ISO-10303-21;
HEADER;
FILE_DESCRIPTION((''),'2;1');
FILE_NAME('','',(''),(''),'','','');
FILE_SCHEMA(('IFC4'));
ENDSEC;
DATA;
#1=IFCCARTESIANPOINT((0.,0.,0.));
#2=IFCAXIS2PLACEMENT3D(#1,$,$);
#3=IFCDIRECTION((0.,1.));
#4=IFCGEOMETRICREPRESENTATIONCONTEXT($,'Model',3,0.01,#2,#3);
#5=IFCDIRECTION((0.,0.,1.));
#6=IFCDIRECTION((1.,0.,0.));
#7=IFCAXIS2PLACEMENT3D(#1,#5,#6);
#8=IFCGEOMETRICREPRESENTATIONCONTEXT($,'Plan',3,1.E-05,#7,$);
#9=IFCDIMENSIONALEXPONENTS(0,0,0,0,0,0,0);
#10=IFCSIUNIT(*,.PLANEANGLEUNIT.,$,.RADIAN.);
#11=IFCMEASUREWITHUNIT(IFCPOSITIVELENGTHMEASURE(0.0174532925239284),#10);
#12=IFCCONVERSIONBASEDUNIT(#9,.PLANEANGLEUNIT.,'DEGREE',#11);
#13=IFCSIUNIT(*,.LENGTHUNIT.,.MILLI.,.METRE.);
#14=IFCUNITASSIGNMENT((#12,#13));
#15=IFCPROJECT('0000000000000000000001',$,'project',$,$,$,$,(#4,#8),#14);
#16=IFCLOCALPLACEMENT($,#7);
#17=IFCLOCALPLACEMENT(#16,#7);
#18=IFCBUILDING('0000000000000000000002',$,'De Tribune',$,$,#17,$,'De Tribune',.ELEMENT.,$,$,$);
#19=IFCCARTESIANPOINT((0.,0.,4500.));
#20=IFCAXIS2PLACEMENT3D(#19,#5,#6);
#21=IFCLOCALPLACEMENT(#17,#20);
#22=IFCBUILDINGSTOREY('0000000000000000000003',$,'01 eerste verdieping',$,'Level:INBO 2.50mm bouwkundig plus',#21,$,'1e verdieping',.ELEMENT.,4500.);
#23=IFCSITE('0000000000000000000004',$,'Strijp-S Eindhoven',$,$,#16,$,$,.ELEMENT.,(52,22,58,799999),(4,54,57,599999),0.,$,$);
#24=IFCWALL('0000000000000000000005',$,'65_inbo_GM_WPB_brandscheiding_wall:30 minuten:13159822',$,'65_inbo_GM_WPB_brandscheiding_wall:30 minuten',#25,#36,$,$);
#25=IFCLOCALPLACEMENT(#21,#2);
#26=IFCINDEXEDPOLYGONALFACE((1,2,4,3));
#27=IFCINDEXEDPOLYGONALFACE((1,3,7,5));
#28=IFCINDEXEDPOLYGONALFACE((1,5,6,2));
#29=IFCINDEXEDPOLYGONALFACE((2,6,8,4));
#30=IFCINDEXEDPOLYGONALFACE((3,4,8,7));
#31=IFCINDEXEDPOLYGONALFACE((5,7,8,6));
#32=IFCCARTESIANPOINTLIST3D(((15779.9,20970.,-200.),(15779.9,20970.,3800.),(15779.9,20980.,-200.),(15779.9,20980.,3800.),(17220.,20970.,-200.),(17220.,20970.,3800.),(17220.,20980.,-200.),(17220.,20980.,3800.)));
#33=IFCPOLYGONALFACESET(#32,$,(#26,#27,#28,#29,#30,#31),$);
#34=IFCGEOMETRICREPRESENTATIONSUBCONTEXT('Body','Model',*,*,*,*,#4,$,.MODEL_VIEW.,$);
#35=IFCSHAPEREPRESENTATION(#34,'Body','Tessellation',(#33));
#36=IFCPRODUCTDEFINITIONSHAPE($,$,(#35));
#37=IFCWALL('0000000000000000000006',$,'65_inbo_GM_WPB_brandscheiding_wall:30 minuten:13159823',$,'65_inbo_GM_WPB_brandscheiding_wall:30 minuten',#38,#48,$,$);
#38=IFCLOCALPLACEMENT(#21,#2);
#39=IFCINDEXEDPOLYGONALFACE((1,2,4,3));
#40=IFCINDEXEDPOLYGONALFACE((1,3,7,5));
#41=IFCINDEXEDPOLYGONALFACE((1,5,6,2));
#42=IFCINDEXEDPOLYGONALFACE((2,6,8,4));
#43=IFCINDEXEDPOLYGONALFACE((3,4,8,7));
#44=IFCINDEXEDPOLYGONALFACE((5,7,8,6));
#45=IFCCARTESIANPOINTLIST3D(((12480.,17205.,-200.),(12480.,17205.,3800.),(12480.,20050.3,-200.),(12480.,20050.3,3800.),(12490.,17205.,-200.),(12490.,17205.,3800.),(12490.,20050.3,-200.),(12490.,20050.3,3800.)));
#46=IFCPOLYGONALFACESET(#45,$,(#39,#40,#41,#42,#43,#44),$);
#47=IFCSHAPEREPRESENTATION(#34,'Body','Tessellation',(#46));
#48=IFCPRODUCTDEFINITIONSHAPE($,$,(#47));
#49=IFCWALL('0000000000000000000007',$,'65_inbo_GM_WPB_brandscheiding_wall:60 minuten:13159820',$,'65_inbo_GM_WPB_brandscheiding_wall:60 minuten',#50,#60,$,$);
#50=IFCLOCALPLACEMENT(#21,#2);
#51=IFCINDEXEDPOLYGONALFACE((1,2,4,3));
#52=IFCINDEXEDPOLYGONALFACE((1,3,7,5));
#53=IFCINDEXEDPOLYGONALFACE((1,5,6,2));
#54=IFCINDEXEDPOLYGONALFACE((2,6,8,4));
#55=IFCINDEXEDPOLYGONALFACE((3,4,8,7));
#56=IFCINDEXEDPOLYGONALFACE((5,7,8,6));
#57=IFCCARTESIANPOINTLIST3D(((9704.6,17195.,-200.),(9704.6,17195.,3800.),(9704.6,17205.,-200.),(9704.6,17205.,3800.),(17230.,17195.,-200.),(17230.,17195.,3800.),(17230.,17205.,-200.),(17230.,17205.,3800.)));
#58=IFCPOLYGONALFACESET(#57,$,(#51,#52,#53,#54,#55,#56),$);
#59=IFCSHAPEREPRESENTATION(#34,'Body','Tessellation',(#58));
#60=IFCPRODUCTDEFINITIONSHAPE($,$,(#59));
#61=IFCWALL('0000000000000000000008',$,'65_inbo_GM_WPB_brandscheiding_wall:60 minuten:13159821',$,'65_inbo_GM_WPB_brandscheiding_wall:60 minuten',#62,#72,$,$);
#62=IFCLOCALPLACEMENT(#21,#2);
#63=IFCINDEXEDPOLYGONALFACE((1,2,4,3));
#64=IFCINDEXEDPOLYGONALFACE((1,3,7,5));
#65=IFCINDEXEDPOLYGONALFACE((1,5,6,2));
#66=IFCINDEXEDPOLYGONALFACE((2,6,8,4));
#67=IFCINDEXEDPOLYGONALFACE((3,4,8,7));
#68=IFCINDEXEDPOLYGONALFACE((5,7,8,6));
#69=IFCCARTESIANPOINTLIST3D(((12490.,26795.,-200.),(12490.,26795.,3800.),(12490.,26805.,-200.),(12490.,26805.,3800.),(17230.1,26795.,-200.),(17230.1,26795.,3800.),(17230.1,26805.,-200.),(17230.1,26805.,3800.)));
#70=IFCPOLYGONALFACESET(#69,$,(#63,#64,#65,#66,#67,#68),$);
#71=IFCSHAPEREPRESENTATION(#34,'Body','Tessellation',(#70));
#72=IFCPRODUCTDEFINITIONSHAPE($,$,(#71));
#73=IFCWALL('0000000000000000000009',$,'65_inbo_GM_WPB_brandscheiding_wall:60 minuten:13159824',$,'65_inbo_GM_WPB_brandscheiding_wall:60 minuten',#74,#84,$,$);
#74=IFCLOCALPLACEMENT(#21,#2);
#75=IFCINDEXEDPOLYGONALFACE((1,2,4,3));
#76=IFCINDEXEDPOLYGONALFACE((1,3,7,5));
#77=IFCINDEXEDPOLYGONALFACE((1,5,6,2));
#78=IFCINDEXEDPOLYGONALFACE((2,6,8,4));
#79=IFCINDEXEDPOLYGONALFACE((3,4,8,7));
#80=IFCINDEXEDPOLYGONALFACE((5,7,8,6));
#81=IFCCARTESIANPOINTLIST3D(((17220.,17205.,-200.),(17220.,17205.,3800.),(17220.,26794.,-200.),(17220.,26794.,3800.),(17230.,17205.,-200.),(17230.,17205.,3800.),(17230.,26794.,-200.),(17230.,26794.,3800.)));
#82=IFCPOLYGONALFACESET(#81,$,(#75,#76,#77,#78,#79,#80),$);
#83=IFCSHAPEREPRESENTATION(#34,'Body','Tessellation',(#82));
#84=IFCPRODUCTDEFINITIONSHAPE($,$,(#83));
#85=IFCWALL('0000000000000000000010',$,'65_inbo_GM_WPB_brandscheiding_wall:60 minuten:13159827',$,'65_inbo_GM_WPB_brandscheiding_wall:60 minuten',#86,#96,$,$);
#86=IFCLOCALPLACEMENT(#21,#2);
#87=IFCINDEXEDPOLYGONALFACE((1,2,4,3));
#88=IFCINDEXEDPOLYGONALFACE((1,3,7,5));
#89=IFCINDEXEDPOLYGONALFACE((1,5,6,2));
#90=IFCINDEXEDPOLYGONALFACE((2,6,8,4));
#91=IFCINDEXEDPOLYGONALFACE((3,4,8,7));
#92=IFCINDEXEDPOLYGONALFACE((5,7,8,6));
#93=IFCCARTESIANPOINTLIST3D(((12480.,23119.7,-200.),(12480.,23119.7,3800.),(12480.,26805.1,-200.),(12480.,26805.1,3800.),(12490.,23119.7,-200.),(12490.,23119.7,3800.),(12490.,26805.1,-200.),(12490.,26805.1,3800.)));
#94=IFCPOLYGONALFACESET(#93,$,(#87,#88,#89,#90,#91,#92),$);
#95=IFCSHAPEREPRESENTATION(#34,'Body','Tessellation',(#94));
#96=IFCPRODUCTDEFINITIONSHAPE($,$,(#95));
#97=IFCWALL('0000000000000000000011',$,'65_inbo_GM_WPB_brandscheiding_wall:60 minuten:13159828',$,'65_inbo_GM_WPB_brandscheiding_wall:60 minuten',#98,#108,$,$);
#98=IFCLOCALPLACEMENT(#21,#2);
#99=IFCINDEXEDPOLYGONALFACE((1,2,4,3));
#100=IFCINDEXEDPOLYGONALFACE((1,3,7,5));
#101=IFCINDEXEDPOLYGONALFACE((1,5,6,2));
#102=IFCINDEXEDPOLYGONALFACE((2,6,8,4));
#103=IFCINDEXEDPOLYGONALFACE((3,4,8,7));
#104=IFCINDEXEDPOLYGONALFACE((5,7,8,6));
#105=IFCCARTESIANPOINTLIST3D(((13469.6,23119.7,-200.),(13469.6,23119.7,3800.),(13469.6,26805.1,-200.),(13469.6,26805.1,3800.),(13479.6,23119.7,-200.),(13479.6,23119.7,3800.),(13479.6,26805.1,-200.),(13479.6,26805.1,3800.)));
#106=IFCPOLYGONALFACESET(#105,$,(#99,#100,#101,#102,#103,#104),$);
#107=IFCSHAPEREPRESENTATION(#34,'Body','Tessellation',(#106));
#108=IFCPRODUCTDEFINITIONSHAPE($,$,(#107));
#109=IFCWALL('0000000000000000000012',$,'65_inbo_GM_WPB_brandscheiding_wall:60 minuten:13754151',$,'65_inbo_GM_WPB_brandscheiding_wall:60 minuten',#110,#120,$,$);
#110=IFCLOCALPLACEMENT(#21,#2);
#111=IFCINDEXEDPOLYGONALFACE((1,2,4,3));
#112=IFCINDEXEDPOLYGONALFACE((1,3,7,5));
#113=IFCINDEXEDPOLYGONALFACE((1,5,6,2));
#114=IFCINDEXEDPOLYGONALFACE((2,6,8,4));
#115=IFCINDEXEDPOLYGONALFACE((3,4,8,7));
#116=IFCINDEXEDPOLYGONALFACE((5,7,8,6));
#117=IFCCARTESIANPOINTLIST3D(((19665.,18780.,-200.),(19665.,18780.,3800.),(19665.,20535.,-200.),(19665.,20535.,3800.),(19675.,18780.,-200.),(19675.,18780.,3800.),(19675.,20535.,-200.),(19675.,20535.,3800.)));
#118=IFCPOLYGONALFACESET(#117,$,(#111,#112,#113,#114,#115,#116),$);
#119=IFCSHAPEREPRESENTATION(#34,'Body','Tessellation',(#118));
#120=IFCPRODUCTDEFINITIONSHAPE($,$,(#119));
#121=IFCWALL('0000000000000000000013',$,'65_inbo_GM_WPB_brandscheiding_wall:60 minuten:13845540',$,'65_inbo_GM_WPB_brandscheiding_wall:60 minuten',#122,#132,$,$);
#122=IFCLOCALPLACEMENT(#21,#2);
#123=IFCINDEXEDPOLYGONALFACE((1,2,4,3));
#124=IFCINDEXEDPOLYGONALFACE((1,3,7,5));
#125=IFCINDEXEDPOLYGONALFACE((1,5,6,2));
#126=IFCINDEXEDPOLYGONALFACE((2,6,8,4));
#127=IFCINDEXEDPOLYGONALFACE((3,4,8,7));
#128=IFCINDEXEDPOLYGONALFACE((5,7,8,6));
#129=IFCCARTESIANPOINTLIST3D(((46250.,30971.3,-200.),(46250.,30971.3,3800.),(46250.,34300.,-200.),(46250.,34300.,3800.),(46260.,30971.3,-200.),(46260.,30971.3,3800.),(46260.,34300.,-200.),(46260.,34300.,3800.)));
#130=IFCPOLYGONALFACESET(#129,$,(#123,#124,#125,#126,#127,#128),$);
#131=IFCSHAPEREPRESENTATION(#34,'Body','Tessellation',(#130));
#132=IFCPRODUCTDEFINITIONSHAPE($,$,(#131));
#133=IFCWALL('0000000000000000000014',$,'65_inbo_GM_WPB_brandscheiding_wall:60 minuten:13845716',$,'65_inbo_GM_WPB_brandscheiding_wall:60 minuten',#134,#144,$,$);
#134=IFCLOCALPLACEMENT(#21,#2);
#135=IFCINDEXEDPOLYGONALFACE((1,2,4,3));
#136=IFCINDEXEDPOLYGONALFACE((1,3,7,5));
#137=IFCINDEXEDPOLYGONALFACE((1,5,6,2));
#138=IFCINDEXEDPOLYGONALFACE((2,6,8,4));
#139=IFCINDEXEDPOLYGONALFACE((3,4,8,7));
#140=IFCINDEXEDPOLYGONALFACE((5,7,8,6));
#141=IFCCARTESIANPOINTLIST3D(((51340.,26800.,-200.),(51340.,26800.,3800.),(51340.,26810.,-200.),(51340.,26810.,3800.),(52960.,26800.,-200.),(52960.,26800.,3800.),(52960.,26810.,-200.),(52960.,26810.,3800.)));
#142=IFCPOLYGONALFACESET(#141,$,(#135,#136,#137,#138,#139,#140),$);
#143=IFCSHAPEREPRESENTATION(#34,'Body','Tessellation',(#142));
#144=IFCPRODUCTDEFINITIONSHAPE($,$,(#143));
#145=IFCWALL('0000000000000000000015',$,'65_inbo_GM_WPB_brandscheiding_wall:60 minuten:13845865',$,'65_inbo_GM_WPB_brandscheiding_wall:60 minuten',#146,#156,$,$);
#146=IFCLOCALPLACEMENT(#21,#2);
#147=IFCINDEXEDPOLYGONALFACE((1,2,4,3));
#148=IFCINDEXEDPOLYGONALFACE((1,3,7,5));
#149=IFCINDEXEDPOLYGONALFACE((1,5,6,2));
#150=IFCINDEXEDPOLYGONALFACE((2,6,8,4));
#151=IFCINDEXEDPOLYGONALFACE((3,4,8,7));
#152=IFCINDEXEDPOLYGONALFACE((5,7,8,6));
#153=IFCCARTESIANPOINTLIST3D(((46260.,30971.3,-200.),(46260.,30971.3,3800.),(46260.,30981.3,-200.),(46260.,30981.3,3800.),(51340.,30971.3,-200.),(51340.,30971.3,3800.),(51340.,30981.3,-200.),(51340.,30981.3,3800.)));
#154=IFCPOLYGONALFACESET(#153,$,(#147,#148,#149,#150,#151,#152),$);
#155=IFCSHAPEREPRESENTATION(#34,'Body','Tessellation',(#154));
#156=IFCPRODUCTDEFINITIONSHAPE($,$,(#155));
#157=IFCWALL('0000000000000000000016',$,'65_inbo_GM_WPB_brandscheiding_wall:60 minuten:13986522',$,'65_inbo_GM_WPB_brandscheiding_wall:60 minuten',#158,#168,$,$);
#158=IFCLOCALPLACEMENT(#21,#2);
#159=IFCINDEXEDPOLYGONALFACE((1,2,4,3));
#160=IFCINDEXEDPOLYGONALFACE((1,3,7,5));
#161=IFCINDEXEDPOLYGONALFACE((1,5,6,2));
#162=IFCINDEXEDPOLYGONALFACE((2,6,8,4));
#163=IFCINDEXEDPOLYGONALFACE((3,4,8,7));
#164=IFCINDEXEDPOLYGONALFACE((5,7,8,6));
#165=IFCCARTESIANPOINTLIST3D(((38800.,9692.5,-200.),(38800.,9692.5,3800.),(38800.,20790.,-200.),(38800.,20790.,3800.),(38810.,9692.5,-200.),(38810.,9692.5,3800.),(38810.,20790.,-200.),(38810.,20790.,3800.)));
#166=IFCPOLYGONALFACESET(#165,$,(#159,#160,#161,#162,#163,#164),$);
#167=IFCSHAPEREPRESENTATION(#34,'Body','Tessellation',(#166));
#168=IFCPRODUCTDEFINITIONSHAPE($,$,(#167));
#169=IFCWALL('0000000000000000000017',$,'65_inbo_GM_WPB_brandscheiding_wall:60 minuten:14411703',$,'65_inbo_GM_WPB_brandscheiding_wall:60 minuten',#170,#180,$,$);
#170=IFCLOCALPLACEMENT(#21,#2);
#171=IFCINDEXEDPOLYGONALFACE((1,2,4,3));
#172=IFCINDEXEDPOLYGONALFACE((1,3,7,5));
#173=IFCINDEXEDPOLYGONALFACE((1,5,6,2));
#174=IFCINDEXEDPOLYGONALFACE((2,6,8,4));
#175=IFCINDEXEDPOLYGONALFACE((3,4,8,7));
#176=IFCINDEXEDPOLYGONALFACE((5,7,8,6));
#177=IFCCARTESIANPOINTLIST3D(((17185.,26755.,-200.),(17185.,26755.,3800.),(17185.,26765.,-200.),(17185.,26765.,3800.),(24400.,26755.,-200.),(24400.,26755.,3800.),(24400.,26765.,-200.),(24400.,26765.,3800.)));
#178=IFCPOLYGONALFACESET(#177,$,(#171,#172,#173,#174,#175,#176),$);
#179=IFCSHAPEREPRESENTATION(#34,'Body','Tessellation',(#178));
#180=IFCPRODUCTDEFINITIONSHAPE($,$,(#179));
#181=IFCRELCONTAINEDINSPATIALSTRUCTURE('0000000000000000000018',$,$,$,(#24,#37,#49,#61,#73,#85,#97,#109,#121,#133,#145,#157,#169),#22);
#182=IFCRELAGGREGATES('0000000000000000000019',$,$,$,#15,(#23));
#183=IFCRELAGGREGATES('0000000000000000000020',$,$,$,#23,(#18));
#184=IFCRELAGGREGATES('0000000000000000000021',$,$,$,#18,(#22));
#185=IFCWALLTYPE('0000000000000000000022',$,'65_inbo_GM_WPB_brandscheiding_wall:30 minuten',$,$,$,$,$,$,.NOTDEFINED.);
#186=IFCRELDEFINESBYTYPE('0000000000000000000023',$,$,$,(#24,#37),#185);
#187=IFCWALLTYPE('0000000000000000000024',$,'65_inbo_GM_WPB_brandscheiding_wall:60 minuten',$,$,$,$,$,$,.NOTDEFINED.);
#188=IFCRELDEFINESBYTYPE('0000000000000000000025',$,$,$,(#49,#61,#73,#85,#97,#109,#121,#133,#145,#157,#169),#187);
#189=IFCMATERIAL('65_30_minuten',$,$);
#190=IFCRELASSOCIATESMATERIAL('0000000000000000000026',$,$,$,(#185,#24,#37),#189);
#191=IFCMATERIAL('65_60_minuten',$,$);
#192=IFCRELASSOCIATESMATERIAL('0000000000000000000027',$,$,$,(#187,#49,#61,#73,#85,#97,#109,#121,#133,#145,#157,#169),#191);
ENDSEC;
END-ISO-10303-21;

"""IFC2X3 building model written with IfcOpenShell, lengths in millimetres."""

from ifc_helpers import new_model, entity, si_unit, converted_unit, direction, frame, frame_2d, origin, origin_with_axes, origin_2d_with_axis, place, context, subcontext, project, spatial, rectangle, extrude, material, type_object, element, save


model = new_model("IFC2X3")

# Units and contexts
model_context = context("Model", 3, precision=0.01, world=origin(), true_north=direction((0.0, 1.0)))
plan_context = context("Plan", 3, precision=1e-05, world=origin_with_axes())
body_context = subcontext(model_context, "Body", "Model", "MODEL_VIEW")
ifc_project = project(units=[converted_unit("PLANEANGLEUNIT", "DEGREE", entity("IfcPositiveLengthMeasure", 0.0174532925239284), si_unit("PLANEANGLEUNIT", "RADIAN"), dimensions=[0, 0, 0, 0, 0, 0, 0]), si_unit("LENGTHUNIT", "METRE", prefix="MILLI")], contexts=[model_context, plan_context])

# Site, building, storey
site_placement = place(None, origin_with_axes())
site = spatial("IfcSite", under=ifc_project, at=site_placement, Name="Strijp-S Eindhoven", CompositionType="ELEMENT", RefLatitude=(52, 22, 58, 799999), RefLongitude=(4, 54, 57, 599999), RefElevation=0.0)
building_placement = place(site_placement, origin_with_axes())
building = spatial("IfcBuilding", under=site, at=building_placement, Name="De Tribune", LongName="De Tribune", CompositionType="ELEMENT")
storey_placement = place(building_placement, frame((0.0, 0.0, 4500.0), z_axis=(0.0, 0.0, 1.0), x_axis=(1.0, 0.0, 0.0)))
storey = spatial("IfcBuildingStorey", under=building, at=storey_placement, Name="01 eerste verdieping", ObjectType="Level:INBO 2.50mm bouwkundig plus", LongName="1e verdieping", CompositionType="ELEMENT", Elevation=4500.0)

# Shared definitions
ifc_material_1 = material(Name="65_30_minuten")

# Walls
wall_type_1 = type_object("IfcWallType", Name="65_inbo_GM_WPB_brandscheiding_wall:30 minuten", PredefinedType="NOTDEFINED", material=ifc_material_1)
wall_1_placement = place(storey_placement, frame((15779.9, 20794.1, -200.0), z_axis=(0.0, 0.0, 1.0), x_axis=(1.0, 0.0, 0.0)))
element("IfcWall", 1, at=wall_1_placement, inside=storey, type_object=wall_type_1, material=ifc_material_1, Name="65_inbo_GM_WPB_brandscheiding_wall:30 minuten:13159822", ObjectType="65_inbo_GM_WPB_brandscheiding_wall:30 minuten", context=body_context, shape_type="SweptSolid", body=[
    extrude(rectangle(XDim=10.0, YDim=1440.1, at=frame_2d((0.0, 0.0), x_axis=(1.0, 0.0))), frame((720.1, 180.9, 0.0), z_axis=(0.0, 0.0, 1.0), x_axis=(0.0, -1.0, 0.0)), (0.0, 0.0, 1.0), 4000.0),
])
wall_2_placement = place(storey_placement, frame((12445.0, 17205.0, -200.0), z_axis=(0.0, 0.0, 1.0), x_axis=(0.0, 1.0, 0.0)))
element("IfcWall", 2, at=wall_2_placement, inside=storey, type_object=wall_type_1, material=ifc_material_1, Name="65_inbo_GM_WPB_brandscheiding_wall:30 minuten:13159823", ObjectType="65_inbo_GM_WPB_brandscheiding_wall:30 minuten", context=body_context, shape_type="SweptSolid", body=[
    extrude(rectangle(XDim=10.0, YDim=2845.3, at=origin_2d_with_axis()), frame((1422.6, -40.0, 0.0), z_axis=(0.0, 0.0, 1.0), x_axis=(0.0, -1.0, 0.0)), (0.0, 0.0, 1.0), 4000.0),
])
ifc_material_2 = material(Name="65_60_minuten")
wall_type_2 = type_object("IfcWallType", Name="65_inbo_GM_WPB_brandscheiding_wall:60 minuten", PredefinedType="NOTDEFINED", material=ifc_material_2)
wall_3_placement = place(storey_placement, frame((9704.6, 17019.1, -200.0), z_axis=(0.0, 0.0, 1.0), x_axis=(1.0, 0.0, 0.0)))
element("IfcWall", 3, at=wall_3_placement, inside=storey, type_object=wall_type_2, material=ifc_material_2, Name="65_inbo_GM_WPB_brandscheiding_wall:60 minuten:13159820", ObjectType="65_inbo_GM_WPB_brandscheiding_wall:60 minuten", context=body_context, shape_type="SweptSolid", body=[
    extrude(rectangle(XDim=10.0, YDim=7525.4, at=frame_2d((0.0, 0.0), x_axis=(1.0, 0.0))), frame((3762.7, 180.9, 0.0), z_axis=(0.0, 0.0, 1.0), x_axis=(0.0, -1.0, 0.0)), (0.0, 0.0, 1.0), 4000.0),
])
wall_4_placement = place(storey_placement, frame((12490.0, 26619.1, -200.0), z_axis=(0.0, 0.0, 1.0), x_axis=(1.0, 0.0, 0.0)))
element("IfcWall", 4, at=wall_4_placement, inside=storey, type_object=wall_type_2, material=ifc_material_2, Name="65_inbo_GM_WPB_brandscheiding_wall:60 minuten:13159821", ObjectType="65_inbo_GM_WPB_brandscheiding_wall:60 minuten", context=body_context, shape_type="SweptSolid", body=[
    extrude(rectangle(XDim=10.0, YDim=4740.1, at=frame_2d((0.0, 0.0), x_axis=(1.0, 0.0))), frame((2370.1, 180.9, 0.0), z_axis=(0.0, 0.0, 1.0), x_axis=(0.0, -1.0, 0.0)), (0.0, 0.0, 1.0), 4000.0),
])
wall_5_placement = place(storey_placement, frame((17185.0, 17205.0, -200.0), z_axis=(0.0, 0.0, 1.0), x_axis=(0.0, 1.0, 0.0)))
element("IfcWall", 5, at=wall_5_placement, inside=storey, type_object=wall_type_2, material=ifc_material_2, Name="65_inbo_GM_WPB_brandscheiding_wall:60 minuten:13159824", ObjectType="65_inbo_GM_WPB_brandscheiding_wall:60 minuten", context=body_context, shape_type="SweptSolid", body=[
    extrude(rectangle(XDim=10.0, YDim=9589.0, at=frame_2d((0.0, 0.0), x_axis=(1.0, 0.0))), frame((4794.5, -40.0, 0.0), z_axis=(0.0, 0.0, 1.0), x_axis=(0.0, -1.0, 0.0)), (0.0, 0.0, 1.0), 4000.0),
])
for number, where, z_axis, x_axis, name in (
    (6, (12445.0, 23119.7, -200.0), (0.0, 0.0, 1.0), (0.0, 1.0, 0.0), "65_inbo_GM_WPB_brandscheiding_wall:60 minuten:13159827"),
    (7, (13434.6, 23119.7, -200.0), (0.0, 0.0, 1.0), (0.0, 1.0, 0.0), "65_inbo_GM_WPB_brandscheiding_wall:60 minuten:13159828"),
):
    element("IfcWall", number, at=place(storey_placement, frame(where, z_axis=z_axis, x_axis=x_axis)), inside=storey, type_object=wall_type_2, material=ifc_material_2, Name=name, ObjectType="65_inbo_GM_WPB_brandscheiding_wall:60 minuten", context=body_context, shape_type="SweptSolid", body=[
        extrude(rectangle(XDim=10.0, YDim=3685.3, at=origin_2d_with_axis()), frame((1842.7, -40.0, 0.0), z_axis=(0.0, 0.0, 1.0), x_axis=(0.0, -1.0, 0.0)), (0.0, 0.0, 1.0), 4000.0),
    ])
wall_6_placement = place(storey_placement, frame((19630.0, 18780.0, -200.0), z_axis=(0.0, 0.0, 1.0), x_axis=(0.0, 1.0, 0.0)))
element("IfcWall", 8, at=wall_6_placement, inside=storey, type_object=wall_type_2, material=ifc_material_2, Name="65_inbo_GM_WPB_brandscheiding_wall:60 minuten:13754151", ObjectType="65_inbo_GM_WPB_brandscheiding_wall:60 minuten", context=body_context, shape_type="SweptSolid", body=[
    extrude(rectangle(XDim=10.0, YDim=1755.0, at=frame_2d((0.0, 0.0), x_axis=(1.0, 0.0))), frame((877.5, -40.0, 0.0), z_axis=(0.0, 0.0, 1.0), x_axis=(0.0, -1.0, 0.0)), (0.0, 0.0, 1.0), 4000.0),
])
wall_7_placement = place(storey_placement, frame((46215.0, 30971.3, -200.0), z_axis=(0.0, 0.0, 1.0), x_axis=(0.0, 1.0, 0.0)))
element("IfcWall", 9, at=wall_7_placement, inside=storey, type_object=wall_type_2, material=ifc_material_2, Name="65_inbo_GM_WPB_brandscheiding_wall:60 minuten:13845540", ObjectType="65_inbo_GM_WPB_brandscheiding_wall:60 minuten", context=body_context, shape_type="SweptSolid", body=[
    extrude(rectangle(XDim=10.0, YDim=3328.7, at=frame_2d((0.0, 0.0), x_axis=(1.0, 0.0))), frame((1664.3, -40.0, 0.0), z_axis=(0.0, 0.0, 1.0), x_axis=(0.0, -1.0, 0.0)), (0.0, 0.0, 1.0), 4000.0),
])
wall_8_placement = place(storey_placement, frame((51340.0, 26765.0, -200.0), z_axis=(0.0, 0.0, 1.0), x_axis=(1.0, 0.0, 0.0)))
element("IfcWall", 10, at=wall_8_placement, inside=storey, type_object=wall_type_2, material=ifc_material_2, Name="65_inbo_GM_WPB_brandscheiding_wall:60 minuten:13845716", ObjectType="65_inbo_GM_WPB_brandscheiding_wall:60 minuten", context=body_context, shape_type="SweptSolid", body=[
    extrude(rectangle(XDim=1620.0, YDim=10.0, at=frame_2d((0.0, 0.0), x_axis=(1.0, 0.0))), frame((810.0, 40.0, 0.0)), (0.0, 0.0, 1.0), 4000.0),
])
wall_9_placement = place(storey_placement, frame((46260.0, 30936.3, -200.0), z_axis=(0.0, 0.0, 1.0), x_axis=(1.0, 0.0, 0.0)))
element("IfcWall", 11, at=wall_9_placement, inside=storey, type_object=wall_type_2, material=ifc_material_2, Name="65_inbo_GM_WPB_brandscheiding_wall:60 minuten:13845865", ObjectType="65_inbo_GM_WPB_brandscheiding_wall:60 minuten", context=body_context, shape_type="SweptSolid", body=[
    extrude(rectangle(XDim=5080.0, YDim=10.0, at=frame_2d((0.0, 0.0), x_axis=(1.0, 0.0))), frame((2540.0, 40.0, 0.0)), (0.0, 0.0, 1.0), 4000.0),
])
wall_10_placement = place(storey_placement, frame((38765.0, 9692.5, -200.0), z_axis=(0.0, 0.0, 1.0), x_axis=(0.0, 1.0, 0.0)))
element("IfcWall", 12, at=wall_10_placement, inside=storey, type_object=wall_type_2, material=ifc_material_2, Name="65_inbo_GM_WPB_brandscheiding_wall:60 minuten:13986522", ObjectType="65_inbo_GM_WPB_brandscheiding_wall:60 minuten", context=body_context, shape_type="SweptSolid", body=[
    extrude(rectangle(XDim=10.0, YDim=11097.5, at=frame_2d((0.0, 0.0), x_axis=(1.0, 0.0))), frame((5548.8, -40.0, 0.0), z_axis=(0.0, 0.0, 1.0), x_axis=(0.0, -1.0, 0.0)), (0.0, 0.0, 1.0), 4000.0),
])
wall_11_placement = place(storey_placement, frame((17185.0, 26579.1, -200.0), z_axis=(0.0, 0.0, 1.0), x_axis=(1.0, 0.0, 0.0)))
element("IfcWall", 13, at=wall_11_placement, inside=storey, type_object=wall_type_2, material=ifc_material_2, Name="65_inbo_GM_WPB_brandscheiding_wall:60 minuten:14411703", ObjectType="65_inbo_GM_WPB_brandscheiding_wall:60 minuten", context=body_context, shape_type="SweptSolid", body=[
    extrude(rectangle(XDim=10.0, YDim=7215.0, at=frame_2d((0.0, 0.0), x_axis=(1.0, 0.0))), frame((3607.5, 180.9, 0.0), z_axis=(0.0, 0.0, 1.0), x_axis=(0.0, -1.0, 0.0)), (0.0, 0.0, 1.0), 4000.0),
])

save(model, "model.ifc")
